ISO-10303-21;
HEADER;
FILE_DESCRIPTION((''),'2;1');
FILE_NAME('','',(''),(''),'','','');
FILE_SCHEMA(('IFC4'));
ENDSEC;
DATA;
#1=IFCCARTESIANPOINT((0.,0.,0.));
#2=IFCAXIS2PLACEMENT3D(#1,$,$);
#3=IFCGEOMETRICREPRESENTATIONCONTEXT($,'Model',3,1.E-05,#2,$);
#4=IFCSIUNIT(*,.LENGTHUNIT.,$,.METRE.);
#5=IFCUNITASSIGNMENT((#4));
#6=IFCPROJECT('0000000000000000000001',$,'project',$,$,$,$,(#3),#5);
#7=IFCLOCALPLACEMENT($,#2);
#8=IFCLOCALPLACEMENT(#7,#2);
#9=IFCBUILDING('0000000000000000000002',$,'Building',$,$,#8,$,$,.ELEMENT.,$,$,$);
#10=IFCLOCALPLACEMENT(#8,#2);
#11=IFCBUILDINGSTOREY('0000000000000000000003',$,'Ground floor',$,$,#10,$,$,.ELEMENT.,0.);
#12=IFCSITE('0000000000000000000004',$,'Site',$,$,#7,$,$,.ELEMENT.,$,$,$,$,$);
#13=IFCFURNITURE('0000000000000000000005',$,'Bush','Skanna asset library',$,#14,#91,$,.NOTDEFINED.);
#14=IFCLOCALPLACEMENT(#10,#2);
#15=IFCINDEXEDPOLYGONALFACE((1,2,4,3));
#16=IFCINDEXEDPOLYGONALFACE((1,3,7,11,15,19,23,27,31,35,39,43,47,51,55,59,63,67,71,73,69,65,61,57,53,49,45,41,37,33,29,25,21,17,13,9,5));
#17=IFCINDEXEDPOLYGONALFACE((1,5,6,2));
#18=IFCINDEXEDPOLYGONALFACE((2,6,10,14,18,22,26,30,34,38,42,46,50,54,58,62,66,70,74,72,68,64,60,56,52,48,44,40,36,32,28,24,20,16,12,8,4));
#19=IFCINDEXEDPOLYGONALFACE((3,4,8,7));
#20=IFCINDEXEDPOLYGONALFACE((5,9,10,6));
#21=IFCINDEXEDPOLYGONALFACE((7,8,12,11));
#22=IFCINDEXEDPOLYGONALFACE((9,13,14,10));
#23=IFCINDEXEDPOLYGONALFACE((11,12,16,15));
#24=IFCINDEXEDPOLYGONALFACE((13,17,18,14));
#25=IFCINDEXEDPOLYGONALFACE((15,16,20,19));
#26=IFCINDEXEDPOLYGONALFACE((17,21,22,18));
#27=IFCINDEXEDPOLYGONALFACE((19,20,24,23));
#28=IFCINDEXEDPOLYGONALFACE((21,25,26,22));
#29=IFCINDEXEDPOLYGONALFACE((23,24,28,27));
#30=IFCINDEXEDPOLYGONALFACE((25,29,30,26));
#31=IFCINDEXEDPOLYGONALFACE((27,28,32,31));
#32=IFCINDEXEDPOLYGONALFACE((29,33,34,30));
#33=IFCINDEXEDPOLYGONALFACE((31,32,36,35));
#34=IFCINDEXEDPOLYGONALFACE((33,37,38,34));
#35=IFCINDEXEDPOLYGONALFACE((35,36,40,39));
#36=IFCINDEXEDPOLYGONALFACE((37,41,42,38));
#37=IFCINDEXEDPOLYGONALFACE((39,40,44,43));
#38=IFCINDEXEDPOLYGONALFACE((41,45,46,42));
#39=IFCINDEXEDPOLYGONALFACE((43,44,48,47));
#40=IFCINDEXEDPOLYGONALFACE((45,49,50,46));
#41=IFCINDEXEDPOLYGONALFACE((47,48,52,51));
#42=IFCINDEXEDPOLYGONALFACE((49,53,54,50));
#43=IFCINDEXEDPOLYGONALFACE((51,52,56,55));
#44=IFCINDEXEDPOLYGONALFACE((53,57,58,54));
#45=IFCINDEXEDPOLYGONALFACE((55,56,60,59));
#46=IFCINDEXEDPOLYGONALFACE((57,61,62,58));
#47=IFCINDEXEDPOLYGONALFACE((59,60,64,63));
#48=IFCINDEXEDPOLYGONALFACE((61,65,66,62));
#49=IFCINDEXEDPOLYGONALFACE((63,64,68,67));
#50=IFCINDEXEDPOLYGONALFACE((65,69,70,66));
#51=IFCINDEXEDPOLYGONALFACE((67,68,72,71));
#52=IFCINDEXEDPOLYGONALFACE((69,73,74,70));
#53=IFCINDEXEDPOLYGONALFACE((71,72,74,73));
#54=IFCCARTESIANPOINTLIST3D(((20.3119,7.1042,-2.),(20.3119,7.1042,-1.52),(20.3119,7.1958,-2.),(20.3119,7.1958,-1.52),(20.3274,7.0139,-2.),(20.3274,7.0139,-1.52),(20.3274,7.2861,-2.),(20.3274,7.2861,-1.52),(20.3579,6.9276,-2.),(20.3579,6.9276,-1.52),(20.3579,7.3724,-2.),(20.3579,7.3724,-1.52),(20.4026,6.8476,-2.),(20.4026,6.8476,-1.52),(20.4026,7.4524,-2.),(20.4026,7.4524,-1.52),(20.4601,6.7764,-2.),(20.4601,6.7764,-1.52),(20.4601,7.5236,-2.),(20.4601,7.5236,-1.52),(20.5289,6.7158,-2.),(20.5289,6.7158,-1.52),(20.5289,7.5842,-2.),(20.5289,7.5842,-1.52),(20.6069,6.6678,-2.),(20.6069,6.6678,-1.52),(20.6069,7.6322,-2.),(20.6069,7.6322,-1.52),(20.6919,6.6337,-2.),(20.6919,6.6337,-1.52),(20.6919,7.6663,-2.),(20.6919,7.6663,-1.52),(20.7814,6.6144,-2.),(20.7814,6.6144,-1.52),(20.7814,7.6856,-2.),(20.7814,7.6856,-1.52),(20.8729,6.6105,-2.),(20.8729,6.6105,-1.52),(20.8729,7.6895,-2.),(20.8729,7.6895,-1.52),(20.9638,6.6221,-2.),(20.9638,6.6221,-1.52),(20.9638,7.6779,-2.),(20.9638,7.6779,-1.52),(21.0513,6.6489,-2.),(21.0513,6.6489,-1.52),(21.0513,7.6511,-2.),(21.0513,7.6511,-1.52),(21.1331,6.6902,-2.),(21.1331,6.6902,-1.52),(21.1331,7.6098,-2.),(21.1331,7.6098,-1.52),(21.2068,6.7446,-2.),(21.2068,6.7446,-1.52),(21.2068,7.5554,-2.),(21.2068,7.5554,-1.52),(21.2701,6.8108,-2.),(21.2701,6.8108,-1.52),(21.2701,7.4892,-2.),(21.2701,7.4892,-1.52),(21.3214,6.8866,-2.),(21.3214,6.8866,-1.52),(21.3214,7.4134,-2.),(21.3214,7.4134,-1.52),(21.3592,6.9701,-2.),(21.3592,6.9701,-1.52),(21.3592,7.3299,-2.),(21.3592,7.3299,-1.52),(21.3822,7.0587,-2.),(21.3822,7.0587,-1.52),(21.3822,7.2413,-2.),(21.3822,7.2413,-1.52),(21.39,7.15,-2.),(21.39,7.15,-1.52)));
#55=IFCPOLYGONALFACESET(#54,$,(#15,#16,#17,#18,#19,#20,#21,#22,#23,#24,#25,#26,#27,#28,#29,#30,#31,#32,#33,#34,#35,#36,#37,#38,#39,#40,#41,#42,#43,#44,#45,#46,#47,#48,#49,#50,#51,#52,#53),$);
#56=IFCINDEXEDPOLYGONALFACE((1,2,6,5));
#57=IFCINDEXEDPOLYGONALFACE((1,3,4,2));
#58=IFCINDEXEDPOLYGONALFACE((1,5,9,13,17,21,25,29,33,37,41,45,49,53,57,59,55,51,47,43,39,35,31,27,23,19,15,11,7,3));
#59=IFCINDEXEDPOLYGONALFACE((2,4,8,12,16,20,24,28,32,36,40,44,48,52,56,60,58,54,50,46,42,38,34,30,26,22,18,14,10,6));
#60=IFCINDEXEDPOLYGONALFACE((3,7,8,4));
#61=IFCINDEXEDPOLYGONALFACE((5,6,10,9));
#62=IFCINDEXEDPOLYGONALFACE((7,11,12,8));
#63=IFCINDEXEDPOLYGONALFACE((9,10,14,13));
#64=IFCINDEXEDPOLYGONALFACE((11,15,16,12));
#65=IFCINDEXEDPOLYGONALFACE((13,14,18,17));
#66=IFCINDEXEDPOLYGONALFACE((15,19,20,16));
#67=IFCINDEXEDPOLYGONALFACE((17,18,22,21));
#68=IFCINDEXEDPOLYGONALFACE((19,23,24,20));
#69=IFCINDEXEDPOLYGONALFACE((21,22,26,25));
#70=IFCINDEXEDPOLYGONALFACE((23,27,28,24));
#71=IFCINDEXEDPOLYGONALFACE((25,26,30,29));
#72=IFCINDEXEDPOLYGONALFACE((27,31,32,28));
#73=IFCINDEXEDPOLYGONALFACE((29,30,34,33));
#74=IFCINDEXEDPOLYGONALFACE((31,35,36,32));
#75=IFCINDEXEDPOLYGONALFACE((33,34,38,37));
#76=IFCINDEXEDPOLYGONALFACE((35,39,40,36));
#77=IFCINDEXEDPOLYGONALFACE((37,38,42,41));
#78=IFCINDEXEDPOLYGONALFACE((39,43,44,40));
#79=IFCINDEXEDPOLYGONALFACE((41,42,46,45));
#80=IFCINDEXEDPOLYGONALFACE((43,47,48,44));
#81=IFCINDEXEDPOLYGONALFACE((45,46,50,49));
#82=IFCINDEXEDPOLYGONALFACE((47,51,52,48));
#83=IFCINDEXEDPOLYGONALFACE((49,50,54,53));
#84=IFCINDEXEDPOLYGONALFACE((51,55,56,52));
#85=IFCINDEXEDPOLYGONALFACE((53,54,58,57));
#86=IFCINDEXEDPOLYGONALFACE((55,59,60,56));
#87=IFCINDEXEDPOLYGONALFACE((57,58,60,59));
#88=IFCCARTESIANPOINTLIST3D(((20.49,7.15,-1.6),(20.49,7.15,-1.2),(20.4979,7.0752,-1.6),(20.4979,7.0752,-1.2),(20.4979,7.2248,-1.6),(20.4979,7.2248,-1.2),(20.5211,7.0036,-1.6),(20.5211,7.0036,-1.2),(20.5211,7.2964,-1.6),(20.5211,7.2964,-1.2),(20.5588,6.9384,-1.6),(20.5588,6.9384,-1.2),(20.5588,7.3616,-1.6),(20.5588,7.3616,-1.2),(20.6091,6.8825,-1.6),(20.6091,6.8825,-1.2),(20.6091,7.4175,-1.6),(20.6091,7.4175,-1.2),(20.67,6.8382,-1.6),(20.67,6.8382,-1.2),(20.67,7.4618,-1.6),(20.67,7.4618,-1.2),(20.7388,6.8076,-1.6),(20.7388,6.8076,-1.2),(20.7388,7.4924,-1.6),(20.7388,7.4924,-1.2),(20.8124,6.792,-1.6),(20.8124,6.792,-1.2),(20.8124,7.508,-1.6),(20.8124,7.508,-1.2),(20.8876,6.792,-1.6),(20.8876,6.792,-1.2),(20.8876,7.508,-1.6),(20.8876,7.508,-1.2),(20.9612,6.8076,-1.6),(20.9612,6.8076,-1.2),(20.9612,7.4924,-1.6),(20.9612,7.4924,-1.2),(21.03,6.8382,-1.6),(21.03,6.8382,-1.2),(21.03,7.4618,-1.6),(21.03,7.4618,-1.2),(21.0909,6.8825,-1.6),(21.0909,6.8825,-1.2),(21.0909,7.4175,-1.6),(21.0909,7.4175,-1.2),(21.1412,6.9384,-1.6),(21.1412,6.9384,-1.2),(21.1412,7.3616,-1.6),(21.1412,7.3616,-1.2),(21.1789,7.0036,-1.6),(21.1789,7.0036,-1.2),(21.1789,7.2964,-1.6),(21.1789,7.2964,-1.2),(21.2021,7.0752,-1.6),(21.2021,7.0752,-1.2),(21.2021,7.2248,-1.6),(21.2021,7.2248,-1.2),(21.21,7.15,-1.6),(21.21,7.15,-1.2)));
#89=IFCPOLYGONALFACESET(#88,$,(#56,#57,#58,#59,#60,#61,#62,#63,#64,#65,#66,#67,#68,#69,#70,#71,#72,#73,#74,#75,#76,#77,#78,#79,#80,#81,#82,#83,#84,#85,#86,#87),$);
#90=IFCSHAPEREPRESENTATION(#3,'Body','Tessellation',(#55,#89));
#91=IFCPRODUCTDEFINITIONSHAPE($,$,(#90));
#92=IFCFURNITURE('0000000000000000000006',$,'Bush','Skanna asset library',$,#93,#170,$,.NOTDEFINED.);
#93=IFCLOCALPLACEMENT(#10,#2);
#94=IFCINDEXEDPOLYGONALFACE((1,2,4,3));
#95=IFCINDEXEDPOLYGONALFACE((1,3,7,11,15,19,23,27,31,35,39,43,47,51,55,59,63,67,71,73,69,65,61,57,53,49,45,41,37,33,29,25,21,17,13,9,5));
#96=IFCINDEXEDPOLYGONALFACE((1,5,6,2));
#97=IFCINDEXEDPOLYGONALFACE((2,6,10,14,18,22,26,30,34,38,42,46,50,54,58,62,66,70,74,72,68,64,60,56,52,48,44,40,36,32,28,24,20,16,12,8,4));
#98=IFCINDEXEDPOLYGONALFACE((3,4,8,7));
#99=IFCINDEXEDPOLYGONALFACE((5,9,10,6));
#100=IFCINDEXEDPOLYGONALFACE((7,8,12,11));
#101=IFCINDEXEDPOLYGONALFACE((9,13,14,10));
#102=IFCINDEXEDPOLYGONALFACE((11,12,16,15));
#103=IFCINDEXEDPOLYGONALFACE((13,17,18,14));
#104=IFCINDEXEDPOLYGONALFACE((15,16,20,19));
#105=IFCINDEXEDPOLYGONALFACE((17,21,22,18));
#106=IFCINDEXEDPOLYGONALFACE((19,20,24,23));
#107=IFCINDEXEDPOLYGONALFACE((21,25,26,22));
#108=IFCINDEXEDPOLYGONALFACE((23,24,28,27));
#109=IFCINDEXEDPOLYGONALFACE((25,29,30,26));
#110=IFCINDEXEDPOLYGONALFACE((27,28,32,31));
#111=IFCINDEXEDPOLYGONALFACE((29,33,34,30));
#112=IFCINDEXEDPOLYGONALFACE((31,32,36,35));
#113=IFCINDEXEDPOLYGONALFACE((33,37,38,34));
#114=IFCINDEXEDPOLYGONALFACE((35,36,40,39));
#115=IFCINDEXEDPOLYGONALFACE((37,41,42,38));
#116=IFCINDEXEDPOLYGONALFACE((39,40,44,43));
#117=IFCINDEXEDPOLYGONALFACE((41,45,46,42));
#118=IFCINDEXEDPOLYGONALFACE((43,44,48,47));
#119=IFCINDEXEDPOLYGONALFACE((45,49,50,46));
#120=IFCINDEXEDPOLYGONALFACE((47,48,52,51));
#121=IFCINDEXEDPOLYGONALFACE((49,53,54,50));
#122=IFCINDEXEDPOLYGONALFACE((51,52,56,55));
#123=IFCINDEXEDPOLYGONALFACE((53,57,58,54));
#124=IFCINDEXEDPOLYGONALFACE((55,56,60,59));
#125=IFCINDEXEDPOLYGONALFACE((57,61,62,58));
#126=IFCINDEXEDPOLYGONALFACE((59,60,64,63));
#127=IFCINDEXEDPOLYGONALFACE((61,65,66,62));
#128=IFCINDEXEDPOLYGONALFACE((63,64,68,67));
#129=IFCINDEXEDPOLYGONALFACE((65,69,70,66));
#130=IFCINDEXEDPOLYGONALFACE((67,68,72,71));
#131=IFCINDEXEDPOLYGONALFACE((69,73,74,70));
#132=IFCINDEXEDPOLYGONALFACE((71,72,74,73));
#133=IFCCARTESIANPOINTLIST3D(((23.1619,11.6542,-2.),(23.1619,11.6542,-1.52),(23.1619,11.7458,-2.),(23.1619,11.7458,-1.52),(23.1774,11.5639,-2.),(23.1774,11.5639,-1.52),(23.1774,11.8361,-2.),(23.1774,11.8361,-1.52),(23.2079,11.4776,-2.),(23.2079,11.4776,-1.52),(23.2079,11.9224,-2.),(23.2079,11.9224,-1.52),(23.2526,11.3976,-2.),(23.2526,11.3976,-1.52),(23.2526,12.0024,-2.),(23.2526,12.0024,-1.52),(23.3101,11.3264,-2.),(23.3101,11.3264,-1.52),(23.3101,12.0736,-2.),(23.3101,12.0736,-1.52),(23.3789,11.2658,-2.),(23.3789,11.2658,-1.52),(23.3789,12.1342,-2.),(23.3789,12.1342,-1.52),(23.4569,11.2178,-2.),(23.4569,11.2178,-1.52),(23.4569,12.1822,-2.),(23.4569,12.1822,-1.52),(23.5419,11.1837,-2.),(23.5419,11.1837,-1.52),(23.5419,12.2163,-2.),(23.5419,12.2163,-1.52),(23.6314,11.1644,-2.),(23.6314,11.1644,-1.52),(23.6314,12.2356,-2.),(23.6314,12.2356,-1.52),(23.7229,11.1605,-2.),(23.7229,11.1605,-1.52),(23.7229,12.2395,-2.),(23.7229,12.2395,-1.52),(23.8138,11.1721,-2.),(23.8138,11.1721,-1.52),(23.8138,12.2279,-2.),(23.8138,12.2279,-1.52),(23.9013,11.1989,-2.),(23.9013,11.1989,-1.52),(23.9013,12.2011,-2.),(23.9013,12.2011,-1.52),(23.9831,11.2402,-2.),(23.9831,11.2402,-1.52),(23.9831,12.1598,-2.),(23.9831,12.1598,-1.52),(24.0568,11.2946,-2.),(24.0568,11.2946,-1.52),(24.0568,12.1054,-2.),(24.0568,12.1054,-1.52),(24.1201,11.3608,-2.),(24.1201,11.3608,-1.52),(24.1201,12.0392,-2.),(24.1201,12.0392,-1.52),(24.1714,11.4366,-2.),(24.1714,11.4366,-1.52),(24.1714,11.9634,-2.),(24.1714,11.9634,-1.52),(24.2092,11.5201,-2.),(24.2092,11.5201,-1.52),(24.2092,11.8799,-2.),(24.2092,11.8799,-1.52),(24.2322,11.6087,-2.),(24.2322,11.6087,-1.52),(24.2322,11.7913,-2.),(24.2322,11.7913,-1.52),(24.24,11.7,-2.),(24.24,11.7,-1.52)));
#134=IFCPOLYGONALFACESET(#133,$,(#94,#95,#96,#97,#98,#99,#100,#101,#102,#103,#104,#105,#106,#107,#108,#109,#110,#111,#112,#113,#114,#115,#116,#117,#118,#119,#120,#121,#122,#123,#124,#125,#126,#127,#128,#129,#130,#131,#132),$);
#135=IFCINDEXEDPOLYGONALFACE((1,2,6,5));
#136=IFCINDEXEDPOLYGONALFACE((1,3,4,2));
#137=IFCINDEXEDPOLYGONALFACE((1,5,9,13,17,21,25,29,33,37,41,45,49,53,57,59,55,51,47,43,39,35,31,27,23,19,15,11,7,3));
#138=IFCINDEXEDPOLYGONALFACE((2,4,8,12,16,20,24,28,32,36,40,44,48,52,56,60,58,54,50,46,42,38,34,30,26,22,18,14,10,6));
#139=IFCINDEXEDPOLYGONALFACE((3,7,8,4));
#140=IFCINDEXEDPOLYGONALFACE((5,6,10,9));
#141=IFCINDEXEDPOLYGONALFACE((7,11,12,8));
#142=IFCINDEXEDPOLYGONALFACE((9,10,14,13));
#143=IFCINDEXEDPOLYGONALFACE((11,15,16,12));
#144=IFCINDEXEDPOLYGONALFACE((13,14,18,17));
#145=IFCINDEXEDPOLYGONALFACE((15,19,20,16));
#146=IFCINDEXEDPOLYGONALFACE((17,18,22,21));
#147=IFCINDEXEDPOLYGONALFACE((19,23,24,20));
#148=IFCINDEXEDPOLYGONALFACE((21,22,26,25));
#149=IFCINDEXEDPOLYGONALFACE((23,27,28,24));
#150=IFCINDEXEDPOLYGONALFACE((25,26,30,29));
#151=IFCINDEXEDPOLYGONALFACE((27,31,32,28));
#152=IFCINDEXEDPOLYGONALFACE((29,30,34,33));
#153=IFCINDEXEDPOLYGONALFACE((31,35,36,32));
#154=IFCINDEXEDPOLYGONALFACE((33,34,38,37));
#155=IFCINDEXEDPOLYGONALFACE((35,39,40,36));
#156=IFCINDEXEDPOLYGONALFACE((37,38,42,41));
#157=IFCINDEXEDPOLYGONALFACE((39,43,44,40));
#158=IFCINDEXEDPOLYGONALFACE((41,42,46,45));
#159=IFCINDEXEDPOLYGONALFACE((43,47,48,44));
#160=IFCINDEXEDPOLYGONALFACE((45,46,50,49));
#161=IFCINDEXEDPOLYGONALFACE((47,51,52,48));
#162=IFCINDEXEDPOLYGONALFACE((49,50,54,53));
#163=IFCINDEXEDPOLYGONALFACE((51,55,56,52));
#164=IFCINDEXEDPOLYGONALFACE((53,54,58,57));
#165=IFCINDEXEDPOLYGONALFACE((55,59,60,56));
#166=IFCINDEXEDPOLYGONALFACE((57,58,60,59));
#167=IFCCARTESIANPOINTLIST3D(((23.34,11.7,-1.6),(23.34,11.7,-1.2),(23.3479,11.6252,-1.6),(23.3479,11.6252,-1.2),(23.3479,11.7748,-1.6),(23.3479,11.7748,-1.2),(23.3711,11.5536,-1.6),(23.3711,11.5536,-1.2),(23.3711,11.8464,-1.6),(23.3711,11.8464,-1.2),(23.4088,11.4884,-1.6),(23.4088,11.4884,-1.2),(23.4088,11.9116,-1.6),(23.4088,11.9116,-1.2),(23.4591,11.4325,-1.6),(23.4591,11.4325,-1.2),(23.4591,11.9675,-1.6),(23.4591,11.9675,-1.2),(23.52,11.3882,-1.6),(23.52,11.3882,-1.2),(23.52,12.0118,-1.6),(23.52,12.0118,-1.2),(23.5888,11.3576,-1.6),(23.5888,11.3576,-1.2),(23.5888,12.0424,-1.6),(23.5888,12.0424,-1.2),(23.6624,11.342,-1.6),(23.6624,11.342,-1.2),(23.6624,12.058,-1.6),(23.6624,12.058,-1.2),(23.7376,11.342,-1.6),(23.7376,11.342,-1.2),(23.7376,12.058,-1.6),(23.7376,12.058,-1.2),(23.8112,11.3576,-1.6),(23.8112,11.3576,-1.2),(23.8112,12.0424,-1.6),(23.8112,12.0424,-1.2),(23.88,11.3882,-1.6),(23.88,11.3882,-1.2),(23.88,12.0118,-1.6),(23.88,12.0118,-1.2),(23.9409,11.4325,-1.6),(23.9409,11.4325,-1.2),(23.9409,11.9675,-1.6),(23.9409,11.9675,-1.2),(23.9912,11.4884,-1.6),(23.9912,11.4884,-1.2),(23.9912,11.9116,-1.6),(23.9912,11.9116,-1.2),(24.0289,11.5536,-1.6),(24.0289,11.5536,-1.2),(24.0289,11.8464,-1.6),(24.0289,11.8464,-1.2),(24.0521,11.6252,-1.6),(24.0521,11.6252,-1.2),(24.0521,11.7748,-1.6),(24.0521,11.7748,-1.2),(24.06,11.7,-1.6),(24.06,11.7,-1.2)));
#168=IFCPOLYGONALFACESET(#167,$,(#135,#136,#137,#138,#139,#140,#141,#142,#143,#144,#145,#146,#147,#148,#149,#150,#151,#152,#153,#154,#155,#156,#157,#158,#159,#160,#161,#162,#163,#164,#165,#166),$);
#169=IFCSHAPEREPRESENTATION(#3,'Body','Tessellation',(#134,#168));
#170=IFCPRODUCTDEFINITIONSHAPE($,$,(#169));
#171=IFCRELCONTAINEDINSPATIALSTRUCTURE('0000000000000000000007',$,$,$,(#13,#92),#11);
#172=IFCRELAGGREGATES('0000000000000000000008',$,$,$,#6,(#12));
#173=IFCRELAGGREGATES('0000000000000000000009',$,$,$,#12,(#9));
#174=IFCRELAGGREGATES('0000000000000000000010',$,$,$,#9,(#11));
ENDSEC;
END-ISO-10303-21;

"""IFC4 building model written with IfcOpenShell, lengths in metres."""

from ifc_helpers import new_model, si_unit, frame, origin, origin_2d, place, context, project, spatial, circle, extrude, element, save


model = new_model("IFC4")

# Units and contexts
model_context = context("Model", 3, precision=1e-05, world=origin())
ifc_project = project(units=[si_unit("LENGTHUNIT", "METRE")], contexts=[model_context])

# Site, building, storey
site_placement = place(None, origin())
site = spatial("IfcSite", under=ifc_project, at=site_placement, Name="Site", CompositionType="ELEMENT")
building_placement = place(site_placement, origin())
building = spatial("IfcBuilding", under=site, at=building_placement, Name="Building", CompositionType="ELEMENT")
storey_placement = place(building_placement, origin())
storey = spatial("IfcBuildingStorey", under=building, at=storey_placement, Name="Ground floor", CompositionType="ELEMENT", Elevation=0.0)

# Furniture
for number, where, z_axis, x_axis, name in (
    (1, (20.85, 7.15, -2.0), (0.0, 0.0, 1.0), (1.0, 0.0, 0.0), "Bush"),
    (2, (23.7, 11.7, -2.0), (0.0, 0.0, 1.0), (1.0, 0.0, 0.0), "Bush"),
):
    element("IfcFurniture", number, at=place(storey_placement, frame(where, z_axis=z_axis, x_axis=x_axis)), inside=storey, Name=name, Description="Skanna asset library", PredefinedType="NOTDEFINED", context=model_context, shape_type="SweptSolid", body=[
        extrude(circle(Radius=0.54, at=origin_2d()), origin(), (0.0, 0.0, 1.0), 0.48),
        extrude(circle(Radius=0.36, at=origin_2d()), frame((0.0, 0.0, 0.4)), (0.0, 0.0, 1.0), 0.4),
    ])

save(model, "model.ifc")
